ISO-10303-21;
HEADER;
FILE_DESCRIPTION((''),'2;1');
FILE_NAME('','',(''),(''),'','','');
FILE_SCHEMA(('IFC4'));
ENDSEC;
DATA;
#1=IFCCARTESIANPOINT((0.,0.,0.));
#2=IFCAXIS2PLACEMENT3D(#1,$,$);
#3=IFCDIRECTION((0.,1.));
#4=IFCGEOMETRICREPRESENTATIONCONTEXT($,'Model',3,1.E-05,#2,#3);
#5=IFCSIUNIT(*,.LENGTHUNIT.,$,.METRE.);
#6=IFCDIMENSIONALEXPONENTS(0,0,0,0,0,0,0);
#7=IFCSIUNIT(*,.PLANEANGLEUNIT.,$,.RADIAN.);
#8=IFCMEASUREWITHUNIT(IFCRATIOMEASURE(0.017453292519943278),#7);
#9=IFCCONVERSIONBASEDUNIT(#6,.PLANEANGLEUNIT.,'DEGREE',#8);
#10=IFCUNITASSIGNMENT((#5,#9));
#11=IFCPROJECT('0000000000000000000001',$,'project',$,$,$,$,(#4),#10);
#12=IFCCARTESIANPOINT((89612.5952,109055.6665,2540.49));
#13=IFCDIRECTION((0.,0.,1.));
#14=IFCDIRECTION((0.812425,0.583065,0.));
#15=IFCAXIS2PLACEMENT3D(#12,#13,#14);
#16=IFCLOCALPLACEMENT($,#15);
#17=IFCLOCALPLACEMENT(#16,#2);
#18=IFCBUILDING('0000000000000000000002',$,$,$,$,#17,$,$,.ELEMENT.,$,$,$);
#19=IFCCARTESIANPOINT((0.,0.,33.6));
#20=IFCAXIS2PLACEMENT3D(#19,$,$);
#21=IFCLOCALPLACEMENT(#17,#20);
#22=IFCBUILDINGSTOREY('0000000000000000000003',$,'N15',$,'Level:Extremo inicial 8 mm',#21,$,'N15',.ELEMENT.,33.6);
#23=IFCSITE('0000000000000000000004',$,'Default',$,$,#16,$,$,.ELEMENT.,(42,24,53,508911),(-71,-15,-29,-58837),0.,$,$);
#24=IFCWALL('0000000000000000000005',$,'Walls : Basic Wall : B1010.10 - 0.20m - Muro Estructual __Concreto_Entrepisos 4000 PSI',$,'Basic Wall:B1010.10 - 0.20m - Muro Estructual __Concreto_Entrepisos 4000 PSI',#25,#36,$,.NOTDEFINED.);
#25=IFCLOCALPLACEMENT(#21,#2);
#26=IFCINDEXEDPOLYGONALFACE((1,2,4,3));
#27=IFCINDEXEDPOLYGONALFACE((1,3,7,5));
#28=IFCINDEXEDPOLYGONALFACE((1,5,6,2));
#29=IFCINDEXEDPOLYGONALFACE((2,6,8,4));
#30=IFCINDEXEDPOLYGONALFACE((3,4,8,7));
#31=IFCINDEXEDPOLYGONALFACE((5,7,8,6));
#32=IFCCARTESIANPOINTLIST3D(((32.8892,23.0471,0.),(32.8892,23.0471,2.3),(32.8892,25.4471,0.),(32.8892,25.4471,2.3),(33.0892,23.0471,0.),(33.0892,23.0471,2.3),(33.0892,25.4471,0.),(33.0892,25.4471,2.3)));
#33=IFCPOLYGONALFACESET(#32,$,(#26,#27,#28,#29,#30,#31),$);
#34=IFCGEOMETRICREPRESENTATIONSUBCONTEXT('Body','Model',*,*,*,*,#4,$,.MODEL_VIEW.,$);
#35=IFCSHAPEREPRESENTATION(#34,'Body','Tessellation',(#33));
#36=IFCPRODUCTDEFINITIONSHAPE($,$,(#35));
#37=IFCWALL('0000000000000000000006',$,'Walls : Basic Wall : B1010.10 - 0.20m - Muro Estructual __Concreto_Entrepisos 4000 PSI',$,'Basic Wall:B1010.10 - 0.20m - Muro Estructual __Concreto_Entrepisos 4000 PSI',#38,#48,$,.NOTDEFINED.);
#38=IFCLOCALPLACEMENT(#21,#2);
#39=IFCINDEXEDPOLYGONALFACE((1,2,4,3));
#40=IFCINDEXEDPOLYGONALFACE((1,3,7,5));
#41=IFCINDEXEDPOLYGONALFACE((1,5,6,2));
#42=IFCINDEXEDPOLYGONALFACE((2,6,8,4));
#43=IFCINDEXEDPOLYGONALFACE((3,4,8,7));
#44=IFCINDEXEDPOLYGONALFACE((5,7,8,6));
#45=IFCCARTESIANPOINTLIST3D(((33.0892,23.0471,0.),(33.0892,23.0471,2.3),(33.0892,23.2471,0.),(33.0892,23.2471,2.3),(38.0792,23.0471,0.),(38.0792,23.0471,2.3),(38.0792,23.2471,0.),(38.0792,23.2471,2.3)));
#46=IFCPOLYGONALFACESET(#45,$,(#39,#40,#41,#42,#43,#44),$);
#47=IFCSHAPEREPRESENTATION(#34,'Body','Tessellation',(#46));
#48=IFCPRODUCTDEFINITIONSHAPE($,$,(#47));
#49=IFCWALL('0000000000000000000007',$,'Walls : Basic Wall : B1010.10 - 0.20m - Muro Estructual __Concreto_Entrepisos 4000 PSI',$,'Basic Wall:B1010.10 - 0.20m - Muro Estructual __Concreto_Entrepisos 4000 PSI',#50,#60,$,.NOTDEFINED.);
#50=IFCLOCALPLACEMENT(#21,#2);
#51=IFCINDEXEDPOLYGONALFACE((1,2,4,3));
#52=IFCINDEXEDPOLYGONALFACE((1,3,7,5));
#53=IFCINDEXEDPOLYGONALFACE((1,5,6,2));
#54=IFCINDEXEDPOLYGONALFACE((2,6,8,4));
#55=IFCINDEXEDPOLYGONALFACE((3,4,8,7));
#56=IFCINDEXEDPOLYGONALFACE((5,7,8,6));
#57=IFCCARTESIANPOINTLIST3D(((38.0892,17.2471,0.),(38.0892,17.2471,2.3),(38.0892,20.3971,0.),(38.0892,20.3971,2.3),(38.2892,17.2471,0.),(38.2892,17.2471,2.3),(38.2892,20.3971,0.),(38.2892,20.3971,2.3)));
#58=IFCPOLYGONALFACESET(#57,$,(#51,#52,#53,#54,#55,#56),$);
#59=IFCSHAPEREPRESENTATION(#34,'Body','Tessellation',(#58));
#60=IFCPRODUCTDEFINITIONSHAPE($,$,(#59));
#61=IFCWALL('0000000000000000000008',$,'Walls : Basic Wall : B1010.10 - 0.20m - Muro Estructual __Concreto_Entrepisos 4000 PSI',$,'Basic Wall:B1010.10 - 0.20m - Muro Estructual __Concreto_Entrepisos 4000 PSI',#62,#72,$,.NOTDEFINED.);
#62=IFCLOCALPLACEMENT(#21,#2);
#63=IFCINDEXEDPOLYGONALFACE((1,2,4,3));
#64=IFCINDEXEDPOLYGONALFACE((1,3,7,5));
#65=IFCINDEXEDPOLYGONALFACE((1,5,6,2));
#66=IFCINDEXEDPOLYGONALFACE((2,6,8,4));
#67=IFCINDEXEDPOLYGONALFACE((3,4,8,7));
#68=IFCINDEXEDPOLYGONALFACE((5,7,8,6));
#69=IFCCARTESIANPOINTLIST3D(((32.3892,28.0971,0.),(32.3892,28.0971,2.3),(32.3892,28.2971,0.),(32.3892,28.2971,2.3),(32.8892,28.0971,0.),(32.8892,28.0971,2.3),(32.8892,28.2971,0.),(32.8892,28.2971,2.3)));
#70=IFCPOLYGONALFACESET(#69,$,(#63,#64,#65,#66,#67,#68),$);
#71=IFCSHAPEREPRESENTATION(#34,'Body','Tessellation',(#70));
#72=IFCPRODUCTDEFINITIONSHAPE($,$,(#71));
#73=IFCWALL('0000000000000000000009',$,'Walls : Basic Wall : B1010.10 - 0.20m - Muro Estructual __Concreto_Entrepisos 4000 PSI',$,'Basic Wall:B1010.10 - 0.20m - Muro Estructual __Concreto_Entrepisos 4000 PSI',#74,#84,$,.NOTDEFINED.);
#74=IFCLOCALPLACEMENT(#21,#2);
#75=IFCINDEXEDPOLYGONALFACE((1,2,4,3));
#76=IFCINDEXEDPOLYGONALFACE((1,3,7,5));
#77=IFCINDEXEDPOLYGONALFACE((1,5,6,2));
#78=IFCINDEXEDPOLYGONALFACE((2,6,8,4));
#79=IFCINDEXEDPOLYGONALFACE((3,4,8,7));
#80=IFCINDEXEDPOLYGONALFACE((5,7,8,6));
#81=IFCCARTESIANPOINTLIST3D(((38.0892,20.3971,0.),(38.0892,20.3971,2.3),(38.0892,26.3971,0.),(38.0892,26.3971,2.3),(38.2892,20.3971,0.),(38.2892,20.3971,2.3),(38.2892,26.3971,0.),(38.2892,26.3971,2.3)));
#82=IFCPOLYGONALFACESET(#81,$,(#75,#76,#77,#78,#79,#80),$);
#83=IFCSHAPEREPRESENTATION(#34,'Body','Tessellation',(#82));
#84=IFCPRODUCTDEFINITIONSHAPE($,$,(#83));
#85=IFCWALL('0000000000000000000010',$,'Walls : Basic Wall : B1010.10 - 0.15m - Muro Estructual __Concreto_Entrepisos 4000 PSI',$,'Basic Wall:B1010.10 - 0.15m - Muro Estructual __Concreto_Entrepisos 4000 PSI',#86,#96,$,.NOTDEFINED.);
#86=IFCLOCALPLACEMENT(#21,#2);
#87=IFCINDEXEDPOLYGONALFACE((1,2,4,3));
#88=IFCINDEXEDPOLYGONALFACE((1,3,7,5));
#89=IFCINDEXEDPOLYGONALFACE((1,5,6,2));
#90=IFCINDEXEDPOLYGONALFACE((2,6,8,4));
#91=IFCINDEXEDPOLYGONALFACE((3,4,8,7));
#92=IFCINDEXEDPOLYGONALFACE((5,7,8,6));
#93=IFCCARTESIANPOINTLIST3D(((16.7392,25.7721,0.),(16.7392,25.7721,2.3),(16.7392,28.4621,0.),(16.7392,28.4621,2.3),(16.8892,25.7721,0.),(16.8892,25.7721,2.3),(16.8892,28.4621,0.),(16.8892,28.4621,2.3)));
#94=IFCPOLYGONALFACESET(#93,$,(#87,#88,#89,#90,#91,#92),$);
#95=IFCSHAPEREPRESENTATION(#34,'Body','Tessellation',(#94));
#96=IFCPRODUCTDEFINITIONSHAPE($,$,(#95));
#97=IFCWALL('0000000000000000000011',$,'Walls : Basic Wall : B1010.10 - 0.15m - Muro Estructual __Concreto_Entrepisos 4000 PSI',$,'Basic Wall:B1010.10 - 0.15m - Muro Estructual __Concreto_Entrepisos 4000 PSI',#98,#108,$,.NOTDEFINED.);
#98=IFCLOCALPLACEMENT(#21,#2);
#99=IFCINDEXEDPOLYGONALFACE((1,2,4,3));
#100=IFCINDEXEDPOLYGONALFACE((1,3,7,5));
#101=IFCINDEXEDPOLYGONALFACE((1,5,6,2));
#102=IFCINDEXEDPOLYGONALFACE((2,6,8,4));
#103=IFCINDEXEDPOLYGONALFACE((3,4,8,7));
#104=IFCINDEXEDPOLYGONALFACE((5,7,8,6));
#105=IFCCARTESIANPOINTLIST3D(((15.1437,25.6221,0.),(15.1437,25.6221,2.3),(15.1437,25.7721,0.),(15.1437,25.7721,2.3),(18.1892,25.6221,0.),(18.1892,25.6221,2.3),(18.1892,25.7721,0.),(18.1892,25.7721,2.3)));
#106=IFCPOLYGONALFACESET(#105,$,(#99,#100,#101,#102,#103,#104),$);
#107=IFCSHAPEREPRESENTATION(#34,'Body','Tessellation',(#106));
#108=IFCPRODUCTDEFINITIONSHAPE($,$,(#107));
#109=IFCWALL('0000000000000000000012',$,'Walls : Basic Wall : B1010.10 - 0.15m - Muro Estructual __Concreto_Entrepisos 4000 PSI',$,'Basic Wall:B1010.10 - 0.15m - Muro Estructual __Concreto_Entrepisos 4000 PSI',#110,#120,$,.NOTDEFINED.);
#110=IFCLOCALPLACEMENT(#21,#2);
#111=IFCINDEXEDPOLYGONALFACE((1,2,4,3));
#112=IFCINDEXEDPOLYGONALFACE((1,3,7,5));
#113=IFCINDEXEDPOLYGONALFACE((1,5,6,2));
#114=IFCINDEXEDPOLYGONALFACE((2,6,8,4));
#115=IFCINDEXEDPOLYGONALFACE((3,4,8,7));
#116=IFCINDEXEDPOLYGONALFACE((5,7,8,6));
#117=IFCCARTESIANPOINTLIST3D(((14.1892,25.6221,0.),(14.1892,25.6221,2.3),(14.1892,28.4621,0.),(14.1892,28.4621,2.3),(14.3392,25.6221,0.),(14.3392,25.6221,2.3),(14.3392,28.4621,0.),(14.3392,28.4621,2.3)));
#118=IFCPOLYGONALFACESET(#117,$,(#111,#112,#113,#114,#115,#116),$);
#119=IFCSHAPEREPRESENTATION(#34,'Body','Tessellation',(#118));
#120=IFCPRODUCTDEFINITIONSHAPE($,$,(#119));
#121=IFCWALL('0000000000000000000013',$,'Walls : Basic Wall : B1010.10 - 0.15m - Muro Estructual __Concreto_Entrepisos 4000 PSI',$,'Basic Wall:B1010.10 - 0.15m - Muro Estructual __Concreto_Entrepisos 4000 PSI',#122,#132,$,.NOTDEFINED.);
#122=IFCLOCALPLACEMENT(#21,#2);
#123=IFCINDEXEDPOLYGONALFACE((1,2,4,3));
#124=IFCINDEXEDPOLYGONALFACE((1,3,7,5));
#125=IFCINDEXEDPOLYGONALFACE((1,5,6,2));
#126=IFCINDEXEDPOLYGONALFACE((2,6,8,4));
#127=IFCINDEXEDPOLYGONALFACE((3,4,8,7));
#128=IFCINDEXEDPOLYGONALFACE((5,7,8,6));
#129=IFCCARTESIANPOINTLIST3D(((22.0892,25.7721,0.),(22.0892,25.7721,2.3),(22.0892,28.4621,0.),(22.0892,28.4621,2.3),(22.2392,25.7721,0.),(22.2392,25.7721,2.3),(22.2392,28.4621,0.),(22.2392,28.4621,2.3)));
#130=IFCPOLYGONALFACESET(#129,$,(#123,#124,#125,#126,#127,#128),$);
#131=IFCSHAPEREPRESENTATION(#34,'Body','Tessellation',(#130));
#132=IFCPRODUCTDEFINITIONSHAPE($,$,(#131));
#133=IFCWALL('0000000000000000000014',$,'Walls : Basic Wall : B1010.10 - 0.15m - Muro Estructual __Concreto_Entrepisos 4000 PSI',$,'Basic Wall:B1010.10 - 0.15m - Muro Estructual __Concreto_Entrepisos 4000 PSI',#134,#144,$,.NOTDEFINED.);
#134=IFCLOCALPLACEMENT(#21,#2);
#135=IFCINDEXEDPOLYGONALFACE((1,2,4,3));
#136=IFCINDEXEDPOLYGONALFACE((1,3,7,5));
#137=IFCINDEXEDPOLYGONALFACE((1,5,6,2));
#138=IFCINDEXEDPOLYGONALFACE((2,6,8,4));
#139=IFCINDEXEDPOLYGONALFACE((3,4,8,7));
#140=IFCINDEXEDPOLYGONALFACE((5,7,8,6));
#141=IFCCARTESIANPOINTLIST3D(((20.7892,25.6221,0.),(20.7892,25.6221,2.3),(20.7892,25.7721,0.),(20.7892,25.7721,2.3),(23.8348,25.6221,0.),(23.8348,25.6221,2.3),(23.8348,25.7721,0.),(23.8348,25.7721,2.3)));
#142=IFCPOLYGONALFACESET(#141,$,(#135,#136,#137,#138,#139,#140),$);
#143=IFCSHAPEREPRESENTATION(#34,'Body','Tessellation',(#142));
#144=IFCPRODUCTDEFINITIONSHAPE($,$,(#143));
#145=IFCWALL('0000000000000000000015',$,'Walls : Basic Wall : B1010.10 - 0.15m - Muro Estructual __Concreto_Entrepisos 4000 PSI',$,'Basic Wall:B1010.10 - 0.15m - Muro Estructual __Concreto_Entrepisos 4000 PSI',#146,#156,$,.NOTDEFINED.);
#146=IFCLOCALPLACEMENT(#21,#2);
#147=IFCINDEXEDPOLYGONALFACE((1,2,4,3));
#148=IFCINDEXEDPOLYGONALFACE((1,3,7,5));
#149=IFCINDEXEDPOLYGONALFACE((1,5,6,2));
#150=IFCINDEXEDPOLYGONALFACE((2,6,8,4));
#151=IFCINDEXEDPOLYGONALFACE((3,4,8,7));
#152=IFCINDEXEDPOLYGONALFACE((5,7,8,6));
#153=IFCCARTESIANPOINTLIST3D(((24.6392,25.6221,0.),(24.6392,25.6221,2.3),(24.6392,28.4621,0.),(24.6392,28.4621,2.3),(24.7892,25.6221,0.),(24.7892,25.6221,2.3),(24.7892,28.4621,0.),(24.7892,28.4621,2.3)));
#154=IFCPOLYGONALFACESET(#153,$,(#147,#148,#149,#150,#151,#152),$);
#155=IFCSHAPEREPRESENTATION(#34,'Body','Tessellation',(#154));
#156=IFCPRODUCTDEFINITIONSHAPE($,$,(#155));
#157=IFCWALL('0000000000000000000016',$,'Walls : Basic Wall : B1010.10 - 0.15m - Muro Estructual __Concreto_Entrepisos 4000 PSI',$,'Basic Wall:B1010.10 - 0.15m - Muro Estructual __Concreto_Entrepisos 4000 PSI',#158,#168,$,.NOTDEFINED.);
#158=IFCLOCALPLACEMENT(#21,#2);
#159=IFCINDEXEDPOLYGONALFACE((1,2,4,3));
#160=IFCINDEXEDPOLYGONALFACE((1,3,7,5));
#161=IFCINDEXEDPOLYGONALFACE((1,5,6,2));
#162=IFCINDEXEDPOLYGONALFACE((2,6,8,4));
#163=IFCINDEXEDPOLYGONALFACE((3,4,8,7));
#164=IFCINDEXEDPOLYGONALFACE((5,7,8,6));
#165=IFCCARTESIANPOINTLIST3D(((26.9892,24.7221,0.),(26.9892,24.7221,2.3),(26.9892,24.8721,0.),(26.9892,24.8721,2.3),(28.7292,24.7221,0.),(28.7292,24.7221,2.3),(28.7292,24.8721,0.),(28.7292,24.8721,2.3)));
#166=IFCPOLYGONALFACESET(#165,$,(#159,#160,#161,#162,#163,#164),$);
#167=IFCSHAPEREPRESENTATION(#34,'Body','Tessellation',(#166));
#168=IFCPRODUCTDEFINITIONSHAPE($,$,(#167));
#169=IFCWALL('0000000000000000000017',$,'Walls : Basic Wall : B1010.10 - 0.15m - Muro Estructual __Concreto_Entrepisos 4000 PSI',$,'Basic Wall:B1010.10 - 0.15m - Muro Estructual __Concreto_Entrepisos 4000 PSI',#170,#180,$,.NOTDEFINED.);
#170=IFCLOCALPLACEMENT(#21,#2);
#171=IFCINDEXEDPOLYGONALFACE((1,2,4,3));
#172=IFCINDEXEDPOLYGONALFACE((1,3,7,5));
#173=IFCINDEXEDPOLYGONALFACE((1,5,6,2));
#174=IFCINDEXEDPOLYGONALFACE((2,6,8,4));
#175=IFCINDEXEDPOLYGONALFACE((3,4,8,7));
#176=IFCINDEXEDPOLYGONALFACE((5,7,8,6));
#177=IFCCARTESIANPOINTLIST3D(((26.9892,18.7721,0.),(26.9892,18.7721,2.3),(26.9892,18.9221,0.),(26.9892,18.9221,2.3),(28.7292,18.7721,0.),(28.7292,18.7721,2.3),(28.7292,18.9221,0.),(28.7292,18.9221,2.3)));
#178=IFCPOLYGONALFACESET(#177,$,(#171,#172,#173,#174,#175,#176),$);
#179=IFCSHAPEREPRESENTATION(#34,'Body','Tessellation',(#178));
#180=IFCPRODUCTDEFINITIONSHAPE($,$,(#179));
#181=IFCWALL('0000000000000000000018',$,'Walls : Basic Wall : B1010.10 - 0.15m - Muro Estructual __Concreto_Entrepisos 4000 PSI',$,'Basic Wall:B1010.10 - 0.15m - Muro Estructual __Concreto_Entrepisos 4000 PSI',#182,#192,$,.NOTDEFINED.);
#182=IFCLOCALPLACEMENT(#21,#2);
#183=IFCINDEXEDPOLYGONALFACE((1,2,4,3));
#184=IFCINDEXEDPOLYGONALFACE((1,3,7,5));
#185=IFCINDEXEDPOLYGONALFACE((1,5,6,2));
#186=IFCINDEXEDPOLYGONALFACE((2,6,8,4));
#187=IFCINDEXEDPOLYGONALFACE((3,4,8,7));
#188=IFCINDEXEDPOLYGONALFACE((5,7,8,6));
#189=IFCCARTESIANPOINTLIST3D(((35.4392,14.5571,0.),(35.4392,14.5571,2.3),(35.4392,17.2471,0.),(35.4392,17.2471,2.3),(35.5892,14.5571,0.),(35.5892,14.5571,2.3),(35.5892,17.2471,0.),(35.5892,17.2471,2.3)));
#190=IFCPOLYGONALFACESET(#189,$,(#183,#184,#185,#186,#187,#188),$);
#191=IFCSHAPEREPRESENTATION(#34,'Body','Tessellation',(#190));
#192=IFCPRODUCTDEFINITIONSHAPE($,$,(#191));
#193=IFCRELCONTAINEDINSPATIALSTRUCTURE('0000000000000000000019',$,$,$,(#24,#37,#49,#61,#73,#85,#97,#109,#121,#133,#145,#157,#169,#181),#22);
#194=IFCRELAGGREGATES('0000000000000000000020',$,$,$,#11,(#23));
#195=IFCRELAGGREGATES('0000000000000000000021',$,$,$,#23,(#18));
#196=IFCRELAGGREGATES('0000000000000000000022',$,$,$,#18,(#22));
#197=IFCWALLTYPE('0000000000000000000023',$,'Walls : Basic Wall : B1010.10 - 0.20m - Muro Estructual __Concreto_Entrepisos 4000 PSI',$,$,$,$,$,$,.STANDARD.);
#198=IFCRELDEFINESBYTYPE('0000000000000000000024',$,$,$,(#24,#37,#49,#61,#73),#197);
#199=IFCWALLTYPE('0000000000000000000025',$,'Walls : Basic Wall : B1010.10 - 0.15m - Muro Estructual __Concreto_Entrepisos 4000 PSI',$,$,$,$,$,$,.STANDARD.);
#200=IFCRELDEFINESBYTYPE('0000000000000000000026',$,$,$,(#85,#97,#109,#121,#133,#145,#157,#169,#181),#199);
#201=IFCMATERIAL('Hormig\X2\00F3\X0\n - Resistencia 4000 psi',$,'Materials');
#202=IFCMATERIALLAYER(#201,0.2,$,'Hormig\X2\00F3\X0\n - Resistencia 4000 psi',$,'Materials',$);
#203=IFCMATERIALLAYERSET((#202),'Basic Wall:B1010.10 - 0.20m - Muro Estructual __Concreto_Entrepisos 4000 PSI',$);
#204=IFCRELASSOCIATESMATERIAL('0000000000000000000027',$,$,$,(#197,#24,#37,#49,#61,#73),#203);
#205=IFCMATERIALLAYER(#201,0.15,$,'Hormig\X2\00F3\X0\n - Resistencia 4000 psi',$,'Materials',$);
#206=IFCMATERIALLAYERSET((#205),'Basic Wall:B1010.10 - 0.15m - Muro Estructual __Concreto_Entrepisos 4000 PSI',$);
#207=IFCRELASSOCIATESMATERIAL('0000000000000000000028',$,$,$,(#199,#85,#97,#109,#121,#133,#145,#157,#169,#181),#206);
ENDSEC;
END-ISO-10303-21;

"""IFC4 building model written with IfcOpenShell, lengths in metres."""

from ifc_helpers import new_model, entity, si_unit, converted_unit, direction, frame, frame_2d, origin, place, context, subcontext, project, spatial, rectangle, extrude, material, layer, layer_set, layer_usage, type_object, element, save


model = new_model("IFC4")

# Units and contexts
model_context = context("Model", 3, precision=1e-05, world=origin(), true_north=direction((0.0, 1.0)))
body_context = subcontext(model_context, "Body", "Model", "MODEL_VIEW")
ifc_project = project(units=[si_unit("LENGTHUNIT", "METRE"), converted_unit("PLANEANGLEUNIT", "DEGREE", entity("IfcRatioMeasure", 0.017453292519943278), si_unit("PLANEANGLEUNIT", "RADIAN"), dimensions=[0, 0, 0, 0, 0, 0, 0])], contexts=[model_context])

# Site, building, storey
site_placement = place(None, frame((89612.5952, 109055.6665, 2540.49), z_axis=(0.0, 0.0, 1.0), x_axis=(0.812425, 0.583065, 0.0)))
site = spatial("IfcSite", under=ifc_project, at=site_placement, Name="Default", CompositionType="ELEMENT", RefLatitude=(42, 24, 53, 508911), RefLongitude=(-71, -15, -29, -58837), RefElevation=0.0)
building_placement = place(site_placement, origin())
building = spatial("IfcBuilding", under=site, at=building_placement, CompositionType="ELEMENT")
storey_placement = place(building_placement, frame((0.0, 0.0, 33.6)))
storey = spatial("IfcBuildingStorey", under=building, at=storey_placement, Name="N15", ObjectType="Level:Extremo inicial 8 mm", LongName="N15", CompositionType="ELEMENT", Elevation=33.6)

# Walls
ifc_material = material(Name="Hormigón - Resistencia 4000 psi", Category="Materials")
ifc_layer_1 = layer(ifc_material, 0.2, Name="Hormigón - Resistencia 4000 psi", Category="Materials")
ifc_layer_set_1 = layer_set([ifc_layer_1], Name="Basic Wall:B1010.10 - 0.20m - Muro Estructual __Concreto_Entrepisos 4000 PSI")
wall_type_1 = type_object("IfcWallType", Name="Walls : Basic Wall : B1010.10 - 0.20m - Muro Estructual __Concreto_Entrepisos 4000 PSI", PredefinedType="STANDARD", material=ifc_layer_set_1)
ifc_layer_usage_1 = layer_usage(ifc_layer_set_1, "AXIS2", "POSITIVE", -0.1)
wall_1_placement = place(storey_placement, frame((32.9892, 25.4471, 0.0), z_axis=(0.0, 0.0, 1.0), x_axis=(0.0, -1.0, 0.0)))
element("IfcWall", 1, at=wall_1_placement, inside=storey, type_object=wall_type_1, material=ifc_layer_usage_1, Name="Walls : Basic Wall : B1010.10 - 0.20m - Muro Estructual __Concreto_Entrepisos 4000 PSI", ObjectType="Basic Wall:B1010.10 - 0.20m - Muro Estructual __Concreto_Entrepisos 4000 PSI", PredefinedType="NOTDEFINED", context=body_context, shape_type="SweptSolid", body=[
    extrude(rectangle(XDim=2.4, YDim=0.2, at=frame_2d((1.2, 0.0), x_axis=(-1.0, 0.0))), origin(), (0.0, 0.0, 1.0), 2.3),
])
ifc_layer_usage_2 = layer_usage(ifc_layer_set_1, "AXIS2", "POSITIVE", -0.1)
wall_2_placement = place(storey_placement, frame((33.0892, 23.1471, 0.0)))
element("IfcWall", 2, at=wall_2_placement, inside=storey, type_object=wall_type_1, material=ifc_layer_usage_2, Name="Walls : Basic Wall : B1010.10 - 0.20m - Muro Estructual __Concreto_Entrepisos 4000 PSI", ObjectType="Basic Wall:B1010.10 - 0.20m - Muro Estructual __Concreto_Entrepisos 4000 PSI", PredefinedType="NOTDEFINED", context=body_context, shape_type="SweptSolid", body=[
    extrude(rectangle(XDim=4.99, YDim=0.2, at=frame_2d((2.495, 0.0), x_axis=(-1.0, 0.0))), origin(), (0.0, 0.0, 1.0), 2.3),
])
ifc_layer_usage_3 = layer_usage(ifc_layer_set_1, "AXIS2", "POSITIVE", -0.1)
wall_3_placement = place(storey_placement, frame((38.1892, 17.2471, 0.0), z_axis=(0.0, 0.0, 1.0), x_axis=(0.0, 1.0, 0.0)))
element("IfcWall", 3, at=wall_3_placement, inside=storey, type_object=wall_type_1, material=ifc_layer_usage_3, Name="Walls : Basic Wall : B1010.10 - 0.20m - Muro Estructual __Concreto_Entrepisos 4000 PSI", ObjectType="Basic Wall:B1010.10 - 0.20m - Muro Estructual __Concreto_Entrepisos 4000 PSI", PredefinedType="NOTDEFINED", context=body_context, shape_type="SweptSolid", body=[
    extrude(rectangle(XDim=3.15, YDim=0.2, at=frame_2d((1.575, 0.0), x_axis=(-1.0, 0.0))), origin(), (0.0, 0.0, 1.0), 2.3),
])
ifc_layer_usage_4 = layer_usage(ifc_layer_set_1, "AXIS2", "POSITIVE", -0.1)
wall_4_placement = place(storey_placement, frame((32.3892, 28.1971, 0.0)))
element("IfcWall", 4, at=wall_4_placement, inside=storey, type_object=wall_type_1, material=ifc_layer_usage_4, Name="Walls : Basic Wall : B1010.10 - 0.20m - Muro Estructual __Concreto_Entrepisos 4000 PSI", ObjectType="Basic Wall:B1010.10 - 0.20m - Muro Estructual __Concreto_Entrepisos 4000 PSI", PredefinedType="NOTDEFINED", context=body_context, shape_type="SweptSolid", body=[
    extrude(rectangle(XDim=0.5, YDim=0.2, at=frame_2d((0.25, 0.0), x_axis=(-1.0, 0.0))), origin(), (0.0, 0.0, 1.0), 2.3),
])
ifc_layer_usage_5 = layer_usage(ifc_layer_set_1, "AXIS2", "POSITIVE", -0.1)
wall_5_placement = place(storey_placement, frame((38.1892, 20.3971, 0.0), z_axis=(0.0, 0.0, 1.0), x_axis=(0.0, 1.0, 0.0)))
element("IfcWall", 5, at=wall_5_placement, inside=storey, type_object=wall_type_1, material=ifc_layer_usage_5, Name="Walls : Basic Wall : B1010.10 - 0.20m - Muro Estructual __Concreto_Entrepisos 4000 PSI", ObjectType="Basic Wall:B1010.10 - 0.20m - Muro Estructual __Concreto_Entrepisos 4000 PSI", PredefinedType="NOTDEFINED", context=body_context, shape_type="SweptSolid", body=[
    extrude(rectangle(XDim=6.0, YDim=0.2, at=frame_2d((3.0, 0.0), x_axis=(-1.0, 0.0))), origin(), (0.0, 0.0, 1.0), 2.3),
])
ifc_layer_2 = layer(ifc_material, 0.15, Name="Hormigón - Resistencia 4000 psi", Category="Materials")
ifc_layer_set_2 = layer_set([ifc_layer_2], Name="Basic Wall:B1010.10 - 0.15m - Muro Estructual __Concreto_Entrepisos 4000 PSI")
ifc_layer_usage_6 = layer_usage(ifc_layer_set_2, "AXIS2", "POSITIVE", -0.075)
wall_type_2 = type_object("IfcWallType", Name="Walls : Basic Wall : B1010.10 - 0.15m - Muro Estructual __Concreto_Entrepisos 4000 PSI", PredefinedType="STANDARD", material=ifc_layer_set_2)
wall_6_placement = place(storey_placement, frame((16.8142, 28.4621, 0.0), z_axis=(0.0, 0.0, 1.0), x_axis=(0.0, -1.0, 0.0)))
element("IfcWall", 6, at=wall_6_placement, inside=storey, type_object=wall_type_2, material=ifc_layer_usage_6, Name="Walls : Basic Wall : B1010.10 - 0.15m - Muro Estructual __Concreto_Entrepisos 4000 PSI", ObjectType="Basic Wall:B1010.10 - 0.15m - Muro Estructual __Concreto_Entrepisos 4000 PSI", PredefinedType="NOTDEFINED", context=body_context, shape_type="SweptSolid", body=[
    extrude(rectangle(XDim=2.69, YDim=0.15, at=frame_2d((1.345, 0.0), x_axis=(-1.0, 0.0))), origin(), (0.0, 0.0, 1.0), 2.3),
])
ifc_layer_usage_7 = layer_usage(ifc_layer_set_2, "AXIS2", "POSITIVE", -0.075)
wall_7_placement = place(storey_placement, frame((18.1892, 25.6971, 0.0), z_axis=(0.0, 0.0, 1.0), x_axis=(-1.0, 0.0, 0.0)))
element("IfcWall", 7, at=wall_7_placement, inside=storey, type_object=wall_type_2, material=ifc_layer_usage_7, Name="Walls : Basic Wall : B1010.10 - 0.15m - Muro Estructual __Concreto_Entrepisos 4000 PSI", ObjectType="Basic Wall:B1010.10 - 0.15m - Muro Estructual __Concreto_Entrepisos 4000 PSI", PredefinedType="NOTDEFINED", context=body_context, shape_type="SweptSolid", body=[
    extrude(rectangle(XDim=3.0455, YDim=0.15, at=frame_2d((1.5228, 0.0), x_axis=(-1.0, 0.0))), origin(), (0.0, 0.0, 1.0), 2.3),
])
ifc_layer_usage_8 = layer_usage(ifc_layer_set_2, "AXIS2", "POSITIVE", -0.075)
wall_8_placement = place(storey_placement, frame((14.2642, 28.4621, 0.0), z_axis=(0.0, 0.0, 1.0), x_axis=(0.0, -1.0, 0.0)))
element("IfcWall", 8, at=wall_8_placement, inside=storey, type_object=wall_type_2, material=ifc_layer_usage_8, Name="Walls : Basic Wall : B1010.10 - 0.15m - Muro Estructual __Concreto_Entrepisos 4000 PSI", ObjectType="Basic Wall:B1010.10 - 0.15m - Muro Estructual __Concreto_Entrepisos 4000 PSI", PredefinedType="NOTDEFINED", context=body_context, shape_type="SweptSolid", body=[
    extrude(rectangle(XDim=2.84, YDim=0.15, at=frame_2d((1.42, 0.0), x_axis=(-1.0, 0.0))), origin(), (0.0, 0.0, 1.0), 2.3),
])
ifc_layer_usage_9 = layer_usage(ifc_layer_set_2, "AXIS2", "NEGATIVE", 0.075)
wall_9_placement = place(storey_placement, frame((22.1642, 28.4621, 0.0), z_axis=(0.0, 0.0, 1.0), x_axis=(0.0, -1.0, 0.0)))
element("IfcWall", 9, at=wall_9_placement, inside=storey, type_object=wall_type_2, material=ifc_layer_usage_9, Name="Walls : Basic Wall : B1010.10 - 0.15m - Muro Estructual __Concreto_Entrepisos 4000 PSI", ObjectType="Basic Wall:B1010.10 - 0.15m - Muro Estructual __Concreto_Entrepisos 4000 PSI", PredefinedType="NOTDEFINED", context=body_context, shape_type="SweptSolid", body=[
    extrude(rectangle(XDim=2.69, YDim=0.15, at=frame_2d((1.345, 0.0), x_axis=(-1.0, 0.0))), origin(), (0.0, 0.0, 1.0), 2.3),
])
ifc_layer_usage_10 = layer_usage(ifc_layer_set_2, "AXIS2", "NEGATIVE", 0.075)
wall_10_placement = place(storey_placement, frame((20.7892, 25.6971, 0.0)))
element("IfcWall", 10, at=wall_10_placement, inside=storey, type_object=wall_type_2, material=ifc_layer_usage_10, Name="Walls : Basic Wall : B1010.10 - 0.15m - Muro Estructual __Concreto_Entrepisos 4000 PSI", ObjectType="Basic Wall:B1010.10 - 0.15m - Muro Estructual __Concreto_Entrepisos 4000 PSI", PredefinedType="NOTDEFINED", context=body_context, shape_type="SweptSolid", body=[
    extrude(rectangle(XDim=3.0455, YDim=0.15, at=frame_2d((1.5228, 0.0), x_axis=(-1.0, 0.0))), origin(), (0.0, 0.0, 1.0), 2.3),
])
ifc_layer_usage_11 = layer_usage(ifc_layer_set_2, "AXIS2", "NEGATIVE", 0.075)
wall_11_placement = place(storey_placement, frame((24.7142, 28.4621, 0.0), z_axis=(0.0, 0.0, 1.0), x_axis=(0.0, -1.0, 0.0)))
element("IfcWall", 11, at=wall_11_placement, inside=storey, type_object=wall_type_2, material=ifc_layer_usage_11, Name="Walls : Basic Wall : B1010.10 - 0.15m - Muro Estructual __Concreto_Entrepisos 4000 PSI", ObjectType="Basic Wall:B1010.10 - 0.15m - Muro Estructual __Concreto_Entrepisos 4000 PSI", PredefinedType="NOTDEFINED", context=body_context, shape_type="SweptSolid", body=[
    extrude(rectangle(XDim=2.84, YDim=0.15, at=frame_2d((1.42, 0.0), x_axis=(-1.0, 0.0))), origin(), (0.0, 0.0, 1.0), 2.3),
])
ifc_layer_usage_12 = layer_usage(ifc_layer_set_2, "AXIS2", "NEGATIVE", 0.075)
wall_12_placement = place(storey_placement, frame((26.9892, 24.7971, 0.0)))
element("IfcWall", 12, at=wall_12_placement, inside=storey, type_object=wall_type_2, material=ifc_layer_usage_12, Name="Walls : Basic Wall : B1010.10 - 0.15m - Muro Estructual __Concreto_Entrepisos 4000 PSI", ObjectType="Basic Wall:B1010.10 - 0.15m - Muro Estructual __Concreto_Entrepisos 4000 PSI", PredefinedType="NOTDEFINED", context=body_context, shape_type="SweptSolid", body=[
    extrude(rectangle(XDim=1.74, YDim=0.15, at=frame_2d((0.87, 0.0), x_axis=(-1.0, 0.0))), origin(), (0.0, 0.0, 1.0), 2.3),
])
ifc_layer_usage_13 = layer_usage(ifc_layer_set_2, "AXIS2", "POSITIVE", -0.075)
wall_13_placement = place(storey_placement, frame((26.9892, 18.8471, 0.0)))
element("IfcWall", 13, at=wall_13_placement, inside=storey, type_object=wall_type_2, material=ifc_layer_usage_13, Name="Walls : Basic Wall : B1010.10 - 0.15m - Muro Estructual __Concreto_Entrepisos 4000 PSI", ObjectType="Basic Wall:B1010.10 - 0.15m - Muro Estructual __Concreto_Entrepisos 4000 PSI", PredefinedType="NOTDEFINED", context=body_context, shape_type="SweptSolid", body=[
    extrude(rectangle(XDim=1.74, YDim=0.15, at=frame_2d((0.87, 0.0), x_axis=(-1.0, 0.0))), origin(), (0.0, 0.0, 1.0), 2.3),
])
ifc_layer_usage_14 = layer_usage(ifc_layer_set_2, "AXIS2", "NEGATIVE", 0.075)
wall_14_placement = place(storey_placement, frame((35.5142, 14.5571, 0.0), z_axis=(0.0, 0.0, 1.0), x_axis=(0.0, 1.0, 0.0)))
element("IfcWall", 14, at=wall_14_placement, inside=storey, type_object=wall_type_2, material=ifc_layer_usage_14, Name="Walls : Basic Wall : B1010.10 - 0.15m - Muro Estructual __Concreto_Entrepisos 4000 PSI", ObjectType="Basic Wall:B1010.10 - 0.15m - Muro Estructual __Concreto_Entrepisos 4000 PSI", PredefinedType="NOTDEFINED", context=body_context, shape_type="SweptSolid", body=[
    extrude(rectangle(XDim=2.69, YDim=0.15, at=frame_2d((1.345, 0.0), x_axis=(-1.0, 0.0))), origin(), (0.0, 0.0, 1.0), 2.3),
])

save(model, "model.ifc")
